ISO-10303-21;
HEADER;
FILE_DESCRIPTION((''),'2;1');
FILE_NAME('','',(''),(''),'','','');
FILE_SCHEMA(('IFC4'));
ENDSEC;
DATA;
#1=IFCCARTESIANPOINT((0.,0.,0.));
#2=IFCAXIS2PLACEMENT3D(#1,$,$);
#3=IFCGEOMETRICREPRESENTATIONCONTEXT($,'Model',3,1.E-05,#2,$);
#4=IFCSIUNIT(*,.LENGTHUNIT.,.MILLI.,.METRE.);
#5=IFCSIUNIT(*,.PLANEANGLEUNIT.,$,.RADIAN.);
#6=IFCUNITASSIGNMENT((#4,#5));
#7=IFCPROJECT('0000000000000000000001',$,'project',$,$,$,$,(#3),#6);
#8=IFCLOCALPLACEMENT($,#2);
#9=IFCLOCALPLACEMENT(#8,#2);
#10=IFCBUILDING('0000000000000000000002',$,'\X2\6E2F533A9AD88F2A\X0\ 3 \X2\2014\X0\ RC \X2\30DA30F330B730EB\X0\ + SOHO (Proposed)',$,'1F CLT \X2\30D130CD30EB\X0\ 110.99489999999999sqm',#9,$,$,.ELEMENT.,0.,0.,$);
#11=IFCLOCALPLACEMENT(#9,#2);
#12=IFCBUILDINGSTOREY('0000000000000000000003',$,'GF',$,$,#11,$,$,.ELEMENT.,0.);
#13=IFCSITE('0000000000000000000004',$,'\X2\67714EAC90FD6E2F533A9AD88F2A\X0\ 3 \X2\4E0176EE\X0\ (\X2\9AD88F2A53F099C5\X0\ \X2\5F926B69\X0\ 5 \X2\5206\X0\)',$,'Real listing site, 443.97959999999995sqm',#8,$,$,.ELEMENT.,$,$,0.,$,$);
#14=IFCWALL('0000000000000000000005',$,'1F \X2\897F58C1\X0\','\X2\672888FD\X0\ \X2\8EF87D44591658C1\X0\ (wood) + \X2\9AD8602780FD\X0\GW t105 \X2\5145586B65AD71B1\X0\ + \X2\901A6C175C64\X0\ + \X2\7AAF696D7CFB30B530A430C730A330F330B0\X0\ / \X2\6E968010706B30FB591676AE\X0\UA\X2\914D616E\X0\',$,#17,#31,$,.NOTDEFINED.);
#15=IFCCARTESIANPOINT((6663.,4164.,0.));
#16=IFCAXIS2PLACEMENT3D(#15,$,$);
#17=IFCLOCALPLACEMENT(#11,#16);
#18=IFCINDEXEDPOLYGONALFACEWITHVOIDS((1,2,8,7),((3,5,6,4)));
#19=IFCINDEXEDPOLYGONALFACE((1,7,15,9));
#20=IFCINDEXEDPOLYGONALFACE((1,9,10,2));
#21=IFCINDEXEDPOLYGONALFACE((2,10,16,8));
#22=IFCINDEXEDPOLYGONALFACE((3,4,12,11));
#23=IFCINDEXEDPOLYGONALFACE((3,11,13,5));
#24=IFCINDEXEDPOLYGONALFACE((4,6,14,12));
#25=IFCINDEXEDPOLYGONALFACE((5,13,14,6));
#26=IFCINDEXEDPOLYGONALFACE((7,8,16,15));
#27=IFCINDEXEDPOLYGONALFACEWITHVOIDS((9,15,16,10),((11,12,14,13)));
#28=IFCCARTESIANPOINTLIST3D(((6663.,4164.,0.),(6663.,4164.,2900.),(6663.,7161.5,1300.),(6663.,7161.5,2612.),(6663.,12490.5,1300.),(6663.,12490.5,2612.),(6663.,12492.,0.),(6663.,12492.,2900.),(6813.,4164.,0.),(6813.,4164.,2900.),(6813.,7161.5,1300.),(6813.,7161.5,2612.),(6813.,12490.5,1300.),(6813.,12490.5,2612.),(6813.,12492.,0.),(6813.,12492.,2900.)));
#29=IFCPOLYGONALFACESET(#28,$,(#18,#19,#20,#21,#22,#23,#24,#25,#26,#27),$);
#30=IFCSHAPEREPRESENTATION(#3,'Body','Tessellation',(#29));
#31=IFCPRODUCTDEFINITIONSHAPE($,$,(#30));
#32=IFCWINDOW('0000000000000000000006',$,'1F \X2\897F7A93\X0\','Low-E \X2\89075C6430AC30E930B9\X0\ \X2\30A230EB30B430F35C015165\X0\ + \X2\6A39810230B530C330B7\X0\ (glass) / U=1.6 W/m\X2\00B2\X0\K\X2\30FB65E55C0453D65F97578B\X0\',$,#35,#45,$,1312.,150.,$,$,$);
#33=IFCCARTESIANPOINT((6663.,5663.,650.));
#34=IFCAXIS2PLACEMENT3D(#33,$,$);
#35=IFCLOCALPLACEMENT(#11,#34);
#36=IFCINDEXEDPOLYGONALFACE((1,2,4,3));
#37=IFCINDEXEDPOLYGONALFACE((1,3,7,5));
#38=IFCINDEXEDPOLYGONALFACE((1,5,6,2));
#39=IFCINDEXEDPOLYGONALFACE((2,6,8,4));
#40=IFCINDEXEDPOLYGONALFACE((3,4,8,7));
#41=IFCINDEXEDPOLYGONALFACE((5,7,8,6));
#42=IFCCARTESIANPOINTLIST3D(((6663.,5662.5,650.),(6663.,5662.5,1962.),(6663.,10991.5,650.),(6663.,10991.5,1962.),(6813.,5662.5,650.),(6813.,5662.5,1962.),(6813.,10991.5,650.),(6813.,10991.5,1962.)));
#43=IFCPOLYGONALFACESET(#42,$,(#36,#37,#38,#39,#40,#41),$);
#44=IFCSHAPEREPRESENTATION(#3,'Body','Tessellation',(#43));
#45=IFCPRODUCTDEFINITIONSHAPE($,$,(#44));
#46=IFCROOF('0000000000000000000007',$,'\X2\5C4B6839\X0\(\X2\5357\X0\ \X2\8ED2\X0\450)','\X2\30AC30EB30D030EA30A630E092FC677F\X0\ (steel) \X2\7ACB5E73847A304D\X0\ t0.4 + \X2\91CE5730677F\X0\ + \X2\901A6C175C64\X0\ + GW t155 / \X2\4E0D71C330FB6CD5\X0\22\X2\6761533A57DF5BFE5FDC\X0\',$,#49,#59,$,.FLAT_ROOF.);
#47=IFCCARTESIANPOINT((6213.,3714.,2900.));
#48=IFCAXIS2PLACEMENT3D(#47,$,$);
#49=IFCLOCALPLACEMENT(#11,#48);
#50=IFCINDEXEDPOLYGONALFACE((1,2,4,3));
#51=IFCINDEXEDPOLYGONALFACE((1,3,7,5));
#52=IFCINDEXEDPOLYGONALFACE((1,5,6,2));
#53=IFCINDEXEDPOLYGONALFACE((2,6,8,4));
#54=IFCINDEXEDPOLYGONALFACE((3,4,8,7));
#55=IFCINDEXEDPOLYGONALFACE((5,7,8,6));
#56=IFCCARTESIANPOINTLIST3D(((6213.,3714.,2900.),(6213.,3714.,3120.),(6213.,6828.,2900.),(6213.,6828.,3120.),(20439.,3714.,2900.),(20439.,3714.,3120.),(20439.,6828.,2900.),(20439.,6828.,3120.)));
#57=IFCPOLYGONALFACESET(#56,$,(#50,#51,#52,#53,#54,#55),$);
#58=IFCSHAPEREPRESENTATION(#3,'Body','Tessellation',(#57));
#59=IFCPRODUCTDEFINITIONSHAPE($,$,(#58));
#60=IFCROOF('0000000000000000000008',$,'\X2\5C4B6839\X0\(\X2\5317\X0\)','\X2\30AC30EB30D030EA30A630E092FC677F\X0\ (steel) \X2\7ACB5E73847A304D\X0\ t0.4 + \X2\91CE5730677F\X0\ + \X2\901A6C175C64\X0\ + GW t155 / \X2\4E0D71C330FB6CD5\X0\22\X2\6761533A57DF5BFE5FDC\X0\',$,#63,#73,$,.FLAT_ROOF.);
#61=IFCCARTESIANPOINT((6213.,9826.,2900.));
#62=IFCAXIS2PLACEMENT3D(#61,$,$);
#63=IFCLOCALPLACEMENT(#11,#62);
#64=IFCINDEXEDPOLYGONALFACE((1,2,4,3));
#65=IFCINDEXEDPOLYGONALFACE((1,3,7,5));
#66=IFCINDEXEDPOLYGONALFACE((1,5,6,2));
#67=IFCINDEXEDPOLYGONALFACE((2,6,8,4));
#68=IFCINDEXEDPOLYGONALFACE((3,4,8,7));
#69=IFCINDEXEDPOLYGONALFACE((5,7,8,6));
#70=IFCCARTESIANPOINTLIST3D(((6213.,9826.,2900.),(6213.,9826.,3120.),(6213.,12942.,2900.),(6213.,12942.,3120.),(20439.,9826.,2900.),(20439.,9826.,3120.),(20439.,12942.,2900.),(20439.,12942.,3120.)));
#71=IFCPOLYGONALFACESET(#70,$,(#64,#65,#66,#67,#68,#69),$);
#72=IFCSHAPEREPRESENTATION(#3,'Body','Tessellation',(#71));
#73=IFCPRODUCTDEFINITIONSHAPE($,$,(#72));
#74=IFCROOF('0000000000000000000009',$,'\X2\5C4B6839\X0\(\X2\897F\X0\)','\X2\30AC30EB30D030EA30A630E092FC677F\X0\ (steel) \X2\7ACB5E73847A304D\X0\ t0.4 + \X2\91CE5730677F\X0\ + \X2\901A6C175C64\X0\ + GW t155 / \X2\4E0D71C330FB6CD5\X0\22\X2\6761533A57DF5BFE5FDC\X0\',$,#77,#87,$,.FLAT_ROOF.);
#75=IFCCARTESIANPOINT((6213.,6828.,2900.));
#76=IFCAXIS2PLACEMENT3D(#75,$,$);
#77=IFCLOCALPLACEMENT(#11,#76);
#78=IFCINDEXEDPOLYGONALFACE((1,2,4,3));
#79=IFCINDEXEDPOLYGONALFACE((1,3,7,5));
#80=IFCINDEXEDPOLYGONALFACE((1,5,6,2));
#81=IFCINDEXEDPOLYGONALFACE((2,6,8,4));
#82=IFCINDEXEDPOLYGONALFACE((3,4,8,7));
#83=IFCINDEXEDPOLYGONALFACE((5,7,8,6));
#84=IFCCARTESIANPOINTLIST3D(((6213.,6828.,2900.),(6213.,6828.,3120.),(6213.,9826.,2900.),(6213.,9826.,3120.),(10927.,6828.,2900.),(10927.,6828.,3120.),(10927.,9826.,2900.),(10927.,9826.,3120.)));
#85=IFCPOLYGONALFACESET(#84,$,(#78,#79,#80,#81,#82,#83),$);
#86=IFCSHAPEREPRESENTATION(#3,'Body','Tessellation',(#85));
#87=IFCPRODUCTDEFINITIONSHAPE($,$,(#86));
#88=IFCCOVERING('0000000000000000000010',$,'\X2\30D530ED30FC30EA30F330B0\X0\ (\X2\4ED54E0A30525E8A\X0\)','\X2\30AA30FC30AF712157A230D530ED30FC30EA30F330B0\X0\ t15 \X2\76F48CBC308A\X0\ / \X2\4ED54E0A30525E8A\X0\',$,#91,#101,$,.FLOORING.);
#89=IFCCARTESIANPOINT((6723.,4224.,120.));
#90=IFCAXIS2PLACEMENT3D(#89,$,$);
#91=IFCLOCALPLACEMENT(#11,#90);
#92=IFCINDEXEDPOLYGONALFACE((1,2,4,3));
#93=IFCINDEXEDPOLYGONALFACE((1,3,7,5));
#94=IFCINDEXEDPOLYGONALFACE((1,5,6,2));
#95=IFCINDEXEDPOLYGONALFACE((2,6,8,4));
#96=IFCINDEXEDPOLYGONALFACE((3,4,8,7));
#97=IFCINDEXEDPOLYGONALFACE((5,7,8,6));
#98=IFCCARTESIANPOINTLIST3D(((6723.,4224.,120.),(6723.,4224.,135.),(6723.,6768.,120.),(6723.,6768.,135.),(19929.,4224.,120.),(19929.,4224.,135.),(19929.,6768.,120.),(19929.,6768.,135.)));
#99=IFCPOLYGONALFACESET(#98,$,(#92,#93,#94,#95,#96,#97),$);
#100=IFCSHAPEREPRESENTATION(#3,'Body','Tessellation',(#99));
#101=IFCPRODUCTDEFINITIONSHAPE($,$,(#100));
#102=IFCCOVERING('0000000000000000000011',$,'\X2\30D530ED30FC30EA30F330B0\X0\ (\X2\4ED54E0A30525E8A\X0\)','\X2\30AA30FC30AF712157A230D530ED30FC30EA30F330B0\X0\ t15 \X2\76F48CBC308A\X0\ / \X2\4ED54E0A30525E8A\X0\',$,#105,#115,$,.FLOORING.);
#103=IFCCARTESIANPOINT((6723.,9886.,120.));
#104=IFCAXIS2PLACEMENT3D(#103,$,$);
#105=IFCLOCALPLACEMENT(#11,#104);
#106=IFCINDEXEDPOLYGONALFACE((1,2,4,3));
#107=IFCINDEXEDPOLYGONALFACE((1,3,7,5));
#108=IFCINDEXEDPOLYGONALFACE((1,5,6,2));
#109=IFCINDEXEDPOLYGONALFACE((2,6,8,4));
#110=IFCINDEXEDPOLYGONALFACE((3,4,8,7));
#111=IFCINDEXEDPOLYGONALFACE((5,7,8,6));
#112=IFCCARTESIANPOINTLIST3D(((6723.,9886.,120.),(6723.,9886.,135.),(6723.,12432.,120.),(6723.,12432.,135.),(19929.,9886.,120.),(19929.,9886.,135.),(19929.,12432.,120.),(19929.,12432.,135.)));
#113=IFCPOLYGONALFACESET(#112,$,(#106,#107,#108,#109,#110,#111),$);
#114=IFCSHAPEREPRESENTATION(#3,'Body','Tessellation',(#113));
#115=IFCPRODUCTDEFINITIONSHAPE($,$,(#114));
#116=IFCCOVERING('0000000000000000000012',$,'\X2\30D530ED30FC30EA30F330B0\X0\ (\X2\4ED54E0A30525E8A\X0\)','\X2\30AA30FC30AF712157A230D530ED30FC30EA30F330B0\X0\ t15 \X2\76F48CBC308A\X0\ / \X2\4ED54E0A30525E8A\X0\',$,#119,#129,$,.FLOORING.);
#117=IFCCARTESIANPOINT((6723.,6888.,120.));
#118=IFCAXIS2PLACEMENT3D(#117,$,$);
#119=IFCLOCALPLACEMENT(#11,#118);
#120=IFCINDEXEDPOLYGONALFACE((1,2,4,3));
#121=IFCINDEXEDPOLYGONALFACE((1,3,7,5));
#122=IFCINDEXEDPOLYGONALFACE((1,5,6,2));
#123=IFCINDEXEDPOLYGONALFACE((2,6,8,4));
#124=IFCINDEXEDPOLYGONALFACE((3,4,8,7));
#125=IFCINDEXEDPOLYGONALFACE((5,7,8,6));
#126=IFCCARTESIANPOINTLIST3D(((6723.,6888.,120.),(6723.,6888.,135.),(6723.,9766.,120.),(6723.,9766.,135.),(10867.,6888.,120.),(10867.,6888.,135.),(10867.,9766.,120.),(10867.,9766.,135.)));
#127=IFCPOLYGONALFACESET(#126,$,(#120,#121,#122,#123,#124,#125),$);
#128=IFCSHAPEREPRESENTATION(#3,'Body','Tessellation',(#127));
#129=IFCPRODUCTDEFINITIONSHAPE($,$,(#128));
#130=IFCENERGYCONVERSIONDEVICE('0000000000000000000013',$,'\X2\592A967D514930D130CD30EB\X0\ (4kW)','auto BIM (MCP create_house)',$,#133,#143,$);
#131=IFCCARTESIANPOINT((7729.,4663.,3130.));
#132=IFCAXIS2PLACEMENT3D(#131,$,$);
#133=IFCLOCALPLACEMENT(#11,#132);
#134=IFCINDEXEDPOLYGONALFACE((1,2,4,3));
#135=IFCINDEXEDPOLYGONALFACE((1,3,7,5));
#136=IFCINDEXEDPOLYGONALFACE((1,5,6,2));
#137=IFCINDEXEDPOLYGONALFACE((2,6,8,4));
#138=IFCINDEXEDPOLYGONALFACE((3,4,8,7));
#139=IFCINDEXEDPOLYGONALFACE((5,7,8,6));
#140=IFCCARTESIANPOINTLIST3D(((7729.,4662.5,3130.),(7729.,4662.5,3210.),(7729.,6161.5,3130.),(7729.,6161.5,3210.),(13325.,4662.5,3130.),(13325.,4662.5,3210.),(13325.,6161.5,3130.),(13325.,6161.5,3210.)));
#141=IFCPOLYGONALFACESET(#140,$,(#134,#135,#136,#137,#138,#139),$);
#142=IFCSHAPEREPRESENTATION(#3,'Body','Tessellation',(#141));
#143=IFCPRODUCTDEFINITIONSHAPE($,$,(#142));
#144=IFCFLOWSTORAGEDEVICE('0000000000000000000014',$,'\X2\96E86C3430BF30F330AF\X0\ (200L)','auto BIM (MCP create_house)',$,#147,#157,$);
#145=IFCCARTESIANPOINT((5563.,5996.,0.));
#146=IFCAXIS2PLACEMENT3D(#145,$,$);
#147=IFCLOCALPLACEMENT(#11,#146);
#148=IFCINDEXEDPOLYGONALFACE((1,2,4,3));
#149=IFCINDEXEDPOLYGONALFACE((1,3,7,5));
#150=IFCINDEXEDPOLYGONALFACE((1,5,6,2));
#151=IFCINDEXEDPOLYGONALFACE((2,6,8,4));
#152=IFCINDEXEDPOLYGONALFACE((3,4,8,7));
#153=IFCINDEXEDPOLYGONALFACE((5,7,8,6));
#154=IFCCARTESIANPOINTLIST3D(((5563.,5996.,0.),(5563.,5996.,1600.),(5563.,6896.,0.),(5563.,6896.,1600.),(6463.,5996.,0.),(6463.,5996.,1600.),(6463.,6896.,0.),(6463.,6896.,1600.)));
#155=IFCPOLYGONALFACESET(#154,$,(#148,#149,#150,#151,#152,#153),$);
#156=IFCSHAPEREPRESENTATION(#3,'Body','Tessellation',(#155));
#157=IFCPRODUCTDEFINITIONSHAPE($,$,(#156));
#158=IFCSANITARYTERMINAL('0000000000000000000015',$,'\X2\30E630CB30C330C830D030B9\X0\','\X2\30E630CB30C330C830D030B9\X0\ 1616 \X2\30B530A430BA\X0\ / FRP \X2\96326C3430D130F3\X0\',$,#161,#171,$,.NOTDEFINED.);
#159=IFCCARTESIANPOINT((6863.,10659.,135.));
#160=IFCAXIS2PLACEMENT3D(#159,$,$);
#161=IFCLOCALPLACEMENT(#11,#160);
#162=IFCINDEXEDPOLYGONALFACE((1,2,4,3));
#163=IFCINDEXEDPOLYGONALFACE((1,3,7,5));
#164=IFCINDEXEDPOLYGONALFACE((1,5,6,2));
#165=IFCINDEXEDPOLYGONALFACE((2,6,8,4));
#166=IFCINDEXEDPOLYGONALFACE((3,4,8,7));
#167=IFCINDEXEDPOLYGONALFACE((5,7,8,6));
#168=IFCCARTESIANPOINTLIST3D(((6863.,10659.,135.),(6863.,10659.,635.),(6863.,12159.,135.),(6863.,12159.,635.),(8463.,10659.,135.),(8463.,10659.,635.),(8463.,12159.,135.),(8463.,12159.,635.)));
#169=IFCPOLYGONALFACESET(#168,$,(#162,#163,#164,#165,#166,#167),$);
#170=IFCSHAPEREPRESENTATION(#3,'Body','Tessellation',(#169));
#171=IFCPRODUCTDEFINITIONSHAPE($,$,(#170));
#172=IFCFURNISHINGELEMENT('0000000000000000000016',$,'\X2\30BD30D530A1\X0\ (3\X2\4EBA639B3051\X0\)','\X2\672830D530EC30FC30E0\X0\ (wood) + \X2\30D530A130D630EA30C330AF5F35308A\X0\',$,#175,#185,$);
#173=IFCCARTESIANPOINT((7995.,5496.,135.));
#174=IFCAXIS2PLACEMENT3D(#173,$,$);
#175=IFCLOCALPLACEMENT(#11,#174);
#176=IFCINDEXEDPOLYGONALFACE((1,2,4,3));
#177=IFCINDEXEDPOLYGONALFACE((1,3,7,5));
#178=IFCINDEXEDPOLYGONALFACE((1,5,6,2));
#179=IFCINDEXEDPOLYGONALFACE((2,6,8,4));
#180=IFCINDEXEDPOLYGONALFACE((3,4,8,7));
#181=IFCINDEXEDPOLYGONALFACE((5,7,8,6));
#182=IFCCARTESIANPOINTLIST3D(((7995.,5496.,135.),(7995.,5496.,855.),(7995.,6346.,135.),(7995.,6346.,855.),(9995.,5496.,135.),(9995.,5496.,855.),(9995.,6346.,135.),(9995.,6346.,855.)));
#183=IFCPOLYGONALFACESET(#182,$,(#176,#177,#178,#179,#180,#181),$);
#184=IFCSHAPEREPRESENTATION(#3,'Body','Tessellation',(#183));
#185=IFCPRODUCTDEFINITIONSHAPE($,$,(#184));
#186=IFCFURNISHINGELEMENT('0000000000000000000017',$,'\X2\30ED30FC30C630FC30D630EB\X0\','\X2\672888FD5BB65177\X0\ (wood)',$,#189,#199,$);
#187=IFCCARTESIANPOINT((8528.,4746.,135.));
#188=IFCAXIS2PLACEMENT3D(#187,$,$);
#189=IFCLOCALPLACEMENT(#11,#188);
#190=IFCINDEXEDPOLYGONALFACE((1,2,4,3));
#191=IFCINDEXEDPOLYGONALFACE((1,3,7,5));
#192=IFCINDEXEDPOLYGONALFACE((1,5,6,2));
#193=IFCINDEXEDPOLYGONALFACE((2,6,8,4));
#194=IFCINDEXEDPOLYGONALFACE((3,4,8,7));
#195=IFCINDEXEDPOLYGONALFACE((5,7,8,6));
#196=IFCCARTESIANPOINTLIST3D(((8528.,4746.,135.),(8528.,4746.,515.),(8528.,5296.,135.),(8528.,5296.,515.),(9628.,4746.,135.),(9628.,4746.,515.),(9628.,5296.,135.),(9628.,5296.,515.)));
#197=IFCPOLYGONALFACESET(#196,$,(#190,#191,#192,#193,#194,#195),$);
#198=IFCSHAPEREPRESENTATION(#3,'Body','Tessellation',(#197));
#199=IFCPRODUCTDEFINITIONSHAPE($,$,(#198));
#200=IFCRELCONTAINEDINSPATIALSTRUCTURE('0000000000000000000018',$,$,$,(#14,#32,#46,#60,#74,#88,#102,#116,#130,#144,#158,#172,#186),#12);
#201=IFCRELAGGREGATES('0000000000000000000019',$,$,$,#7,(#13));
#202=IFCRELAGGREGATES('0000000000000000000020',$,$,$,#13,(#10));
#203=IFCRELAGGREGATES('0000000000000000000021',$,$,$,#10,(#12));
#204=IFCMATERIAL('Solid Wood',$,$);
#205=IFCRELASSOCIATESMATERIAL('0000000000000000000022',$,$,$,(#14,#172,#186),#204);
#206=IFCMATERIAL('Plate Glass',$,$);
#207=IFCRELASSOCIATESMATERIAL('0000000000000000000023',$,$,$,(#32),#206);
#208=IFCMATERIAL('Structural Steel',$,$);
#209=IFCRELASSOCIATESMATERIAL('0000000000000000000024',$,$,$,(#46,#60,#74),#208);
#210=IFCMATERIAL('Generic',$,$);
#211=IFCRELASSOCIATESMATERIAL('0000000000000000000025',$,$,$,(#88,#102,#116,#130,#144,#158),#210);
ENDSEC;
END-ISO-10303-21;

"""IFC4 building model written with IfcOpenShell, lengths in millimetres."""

from ifc_helpers import new_model, si_unit, frame, frame_2d, origin, place, context, project, spatial, rectangle, extrude, material, element, fill, save


model = new_model("IFC4")

# Units and contexts
model_context = context("Model", 3, precision=1e-05, world=origin())
ifc_project = project(units=[si_unit("LENGTHUNIT", "METRE", prefix="MILLI"), si_unit("PLANEANGLEUNIT", "RADIAN")], contexts=[model_context])

# Site, building, storey
site_placement = place(None, origin())
site = spatial("IfcSite", under=ifc_project, at=site_placement, Name="東京都港区高輪 3 丁目 (高輪台駅 徒歩 5 分)", ObjectType="Real listing site, 443.97959999999995sqm", CompositionType="ELEMENT", RefElevation=0.0)
building_placement = place(site_placement, origin())
building = spatial("IfcBuilding", under=site, at=building_placement, Name="港区高輪 3 — RC ペンシル + SOHO (Proposed)", ObjectType="1F CLT パネル 110.99489999999999sqm", CompositionType="ELEMENT", ElevationOfRefHeight=0.0, ElevationOfTerrain=0.0)
storey_placement = place(building_placement, origin())
storey = spatial("IfcBuildingStorey", under=building, at=storey_placement, Name="GF", CompositionType="ELEMENT", Elevation=0.0)

# Shared definitions
ifc_material_1 = material(Name="Solid Wood")

# Shared definitions
ifc_material_2 = material(Name="Plate Glass")

# Wall, opening, window
wall_1_placement = place(storey_placement, frame((6663.0, 4164.0, 0.0)))
wall_1 = element("IfcWall", 1, at=wall_1_placement, inside=storey, material=ifc_material_1, Name="1F 西壁", Description="木製 軸組外壁 (wood) + 高性能GW t105 充填断熱 + 通気層 + 窯業系サイディング / 準耐火・外皮UA配慮", PredefinedType="NOTDEFINED", context=model_context, shape_type="SweptSolid", body=[
    extrude(rectangle(XDim=150.0, YDim=8328.0, at=frame_2d((75.0, 4164.0))), frame((6663.0, 4164.0, 0.0)), (0.0, 0.0, 1.0), 2900.0),
])
opening_1_placement = place(storey_placement, frame((6663.0, 5663.0, 650.0)))
opening_1 = element("IfcOpeningElement", 2, at=opening_1_placement, cuts=wall_1, PredefinedType="NOTDEFINED", context=model_context, shape_type="SweptSolid", body=[
    extrude(rectangle(XDim=150.0, YDim=5329.0, at=frame_2d((75.0, 2664.0))), frame((6663.0, 5663.0, 650.0)), (0.0, 0.0, 1.0), 1312.0),
])
window_1_placement = place(storey_placement, frame((6663.0, 5663.0, 650.0)))
window_1 = element("IfcWindow", 3, at=window_1_placement, inside=storey, material=ifc_material_2, Name="1F 西窓", Description="Low-E 複層ガラス アルゴン封入 + 樹脂サッシ (glass) / U=1.6 W/m²K・日射取得型", OverallHeight=1312.0, OverallWidth=150.0, context=model_context, shape_type="SweptSolid", body=[
    extrude(rectangle(XDim=150.0, YDim=5329.0, at=frame_2d((75.0, 2664.0))), frame((6663.0, 5663.0, 650.0)), (0.0, 0.0, 1.0), 1312.0),
])
fill(opening_1, window_1)

# Roofs
ifc_material_3 = material(Name="Structural Steel")
roof_1_placement = place(storey_placement, frame((6213.0, 3714.0, 2900.0)))
element("IfcRoof", 4, at=roof_1_placement, inside=storey, material=ifc_material_3, Name="屋根(南 軒450)", Description="ガルバリウム鋼板 (steel) 立平葺き t0.4 + 野地板 + 通気層 + GW t155 / 不燃・法22条区域対応", PredefinedType="FLAT_ROOF", context=model_context, shape_type="SweptSolid", body=[
    extrude(rectangle(XDim=14226.0, YDim=3114.0, at=frame_2d((7113.0, 1557.0))), frame((6213.0, 3714.0, 2900.0)), (0.0, 0.0, 1.0), 220.0),
])
roof_2_placement = place(storey_placement, frame((6213.0, 9826.0, 2900.0)))
element("IfcRoof", 5, at=roof_2_placement, inside=storey, material=ifc_material_3, Name="屋根(北)", Description="ガルバリウム鋼板 (steel) 立平葺き t0.4 + 野地板 + 通気層 + GW t155 / 不燃・法22条区域対応", PredefinedType="FLAT_ROOF", context=model_context, shape_type="SweptSolid", body=[
    extrude(rectangle(XDim=14226.0, YDim=3116.0, at=frame_2d((7113.0, 1558.0))), frame((6213.0, 9826.0, 2900.0)), (0.0, 0.0, 1.0), 220.0),
])
roof_3_placement = place(storey_placement, frame((6213.0, 6828.0, 2900.0)))
element("IfcRoof", 6, at=roof_3_placement, inside=storey, material=ifc_material_3, Name="屋根(西)", Description="ガルバリウム鋼板 (steel) 立平葺き t0.4 + 野地板 + 通気層 + GW t155 / 不燃・法22条区域対応", PredefinedType="FLAT_ROOF", context=model_context, shape_type="SweptSolid", body=[
    extrude(rectangle(XDim=4714.0, YDim=2998.0, at=frame_2d((2357.0, 1499.0))), frame((6213.0, 6828.0, 2900.0)), (0.0, 0.0, 1.0), 220.0),
])

# Coverings
ifc_material_4 = material(Name="Generic")
covering_1_placement = place(storey_placement, frame((6723.0, 4224.0, 120.0)))
element("IfcCovering", 7, at=covering_1_placement, inside=storey, material=ifc_material_4, Name="フローリング (仕上げ床)", Description="オーク無垢フローリング t15 直貼り / 仕上げ床", PredefinedType="FLOORING", context=model_context, shape_type="SweptSolid", body=[
    extrude(rectangle(XDim=13206.0, YDim=2544.0, at=frame_2d((6603.0, 1272.0))), frame((6723.0, 4224.0, 120.0)), (0.0, 0.0, 1.0), 15.0),
])
covering_2_placement = place(storey_placement, frame((6723.0, 9886.0, 120.0)))
element("IfcCovering", 8, at=covering_2_placement, inside=storey, material=ifc_material_4, Name="フローリング (仕上げ床)", Description="オーク無垢フローリング t15 直貼り / 仕上げ床", PredefinedType="FLOORING", context=model_context, shape_type="SweptSolid", body=[
    extrude(rectangle(XDim=13206.0, YDim=2546.0, at=frame_2d((6603.0, 1273.0))), frame((6723.0, 9886.0, 120.0)), (0.0, 0.0, 1.0), 15.0),
])
covering_3_placement = place(storey_placement, frame((6723.0, 6888.0, 120.0)))
element("IfcCovering", 9, at=covering_3_placement, inside=storey, material=ifc_material_4, Name="フローリング (仕上げ床)", Description="オーク無垢フローリング t15 直貼り / 仕上げ床", PredefinedType="FLOORING", context=model_context, shape_type="SweptSolid", body=[
    extrude(rectangle(XDim=4144.0, YDim=2878.0, at=frame_2d((2072.0, 1439.0))), frame((6723.0, 6888.0, 120.0)), (0.0, 0.0, 1.0), 15.0),
])

# Energy conversion device
energy_conversion_device_placement = place(storey_placement, frame((7729.0, 4663.0, 3130.0)))
element("IfcEnergyConversionDevice", 10, at=energy_conversion_device_placement, inside=storey, material=ifc_material_4, Name="太陽光パネル (4kW)", Description="auto BIM (MCP create_house)", context=model_context, shape_type="SweptSolid", body=[
    extrude(rectangle(XDim=5596.0, YDim=1499.0, at=frame_2d((2798.0, 749.0))), frame((7729.0, 4663.0, 3130.0)), (0.0, 0.0, 1.0), 80.0),
])

# Flow storage device
flow_storage_device_placement = place(storey_placement, frame((5563.0, 5996.0, 0.0)))
element("IfcFlowStorageDevice", 11, at=flow_storage_device_placement, inside=storey, material=ifc_material_4, Name="雨水タンク (200L)", Description="auto BIM (MCP create_house)", context=model_context, shape_type="SweptSolid", body=[
    extrude(rectangle(XDim=900.0, YDim=900.0, at=frame_2d((450.0, 450.0))), frame((5563.0, 5996.0, 0.0)), (0.0, 0.0, 1.0), 1600.0),
])

# Sanitary terminal
sanitary_terminal_placement = place(storey_placement, frame((6863.0, 10659.0, 135.0)))
element("IfcSanitaryTerminal", 12, at=sanitary_terminal_placement, inside=storey, material=ifc_material_4, Name="ユニットバス", Description="ユニットバス 1616 サイズ / FRP 防水パン", PredefinedType="NOTDEFINED", context=model_context, shape_type="SweptSolid", body=[
    extrude(rectangle(XDim=1600.0, YDim=1500.0, at=frame_2d((800.0, 750.0))), frame((6863.0, 10659.0, 135.0)), (0.0, 0.0, 1.0), 500.0),
])

# Furnishing elements
furnishing_1_placement = place(storey_placement, frame((7995.0, 5496.0, 135.0)))
element("IfcFurnishingElement", 13, at=furnishing_1_placement, inside=storey, material=ifc_material_1, Name="ソファ (3人掛け)", Description="木フレーム (wood) + ファブリック張り", context=model_context, shape_type="SweptSolid", body=[
    extrude(rectangle(XDim=2000.0, YDim=850.0, at=frame_2d((1000.0, 425.0))), frame((7995.0, 5496.0, 135.0)), (0.0, 0.0, 1.0), 720.0),
])
furnishing_2_placement = place(storey_placement, frame((8528.0, 4746.0, 135.0)))
element("IfcFurnishingElement", 14, at=furnishing_2_placement, inside=storey, material=ifc_material_1, Name="ローテーブル", Description="木製家具 (wood)", context=model_context, shape_type="SweptSolid", body=[
    extrude(rectangle(XDim=1100.0, YDim=550.0, at=frame_2d((550.0, 275.0))), frame((8528.0, 4746.0, 135.0)), (0.0, 0.0, 1.0), 380.0),
])

save(model, "model.ifc")
